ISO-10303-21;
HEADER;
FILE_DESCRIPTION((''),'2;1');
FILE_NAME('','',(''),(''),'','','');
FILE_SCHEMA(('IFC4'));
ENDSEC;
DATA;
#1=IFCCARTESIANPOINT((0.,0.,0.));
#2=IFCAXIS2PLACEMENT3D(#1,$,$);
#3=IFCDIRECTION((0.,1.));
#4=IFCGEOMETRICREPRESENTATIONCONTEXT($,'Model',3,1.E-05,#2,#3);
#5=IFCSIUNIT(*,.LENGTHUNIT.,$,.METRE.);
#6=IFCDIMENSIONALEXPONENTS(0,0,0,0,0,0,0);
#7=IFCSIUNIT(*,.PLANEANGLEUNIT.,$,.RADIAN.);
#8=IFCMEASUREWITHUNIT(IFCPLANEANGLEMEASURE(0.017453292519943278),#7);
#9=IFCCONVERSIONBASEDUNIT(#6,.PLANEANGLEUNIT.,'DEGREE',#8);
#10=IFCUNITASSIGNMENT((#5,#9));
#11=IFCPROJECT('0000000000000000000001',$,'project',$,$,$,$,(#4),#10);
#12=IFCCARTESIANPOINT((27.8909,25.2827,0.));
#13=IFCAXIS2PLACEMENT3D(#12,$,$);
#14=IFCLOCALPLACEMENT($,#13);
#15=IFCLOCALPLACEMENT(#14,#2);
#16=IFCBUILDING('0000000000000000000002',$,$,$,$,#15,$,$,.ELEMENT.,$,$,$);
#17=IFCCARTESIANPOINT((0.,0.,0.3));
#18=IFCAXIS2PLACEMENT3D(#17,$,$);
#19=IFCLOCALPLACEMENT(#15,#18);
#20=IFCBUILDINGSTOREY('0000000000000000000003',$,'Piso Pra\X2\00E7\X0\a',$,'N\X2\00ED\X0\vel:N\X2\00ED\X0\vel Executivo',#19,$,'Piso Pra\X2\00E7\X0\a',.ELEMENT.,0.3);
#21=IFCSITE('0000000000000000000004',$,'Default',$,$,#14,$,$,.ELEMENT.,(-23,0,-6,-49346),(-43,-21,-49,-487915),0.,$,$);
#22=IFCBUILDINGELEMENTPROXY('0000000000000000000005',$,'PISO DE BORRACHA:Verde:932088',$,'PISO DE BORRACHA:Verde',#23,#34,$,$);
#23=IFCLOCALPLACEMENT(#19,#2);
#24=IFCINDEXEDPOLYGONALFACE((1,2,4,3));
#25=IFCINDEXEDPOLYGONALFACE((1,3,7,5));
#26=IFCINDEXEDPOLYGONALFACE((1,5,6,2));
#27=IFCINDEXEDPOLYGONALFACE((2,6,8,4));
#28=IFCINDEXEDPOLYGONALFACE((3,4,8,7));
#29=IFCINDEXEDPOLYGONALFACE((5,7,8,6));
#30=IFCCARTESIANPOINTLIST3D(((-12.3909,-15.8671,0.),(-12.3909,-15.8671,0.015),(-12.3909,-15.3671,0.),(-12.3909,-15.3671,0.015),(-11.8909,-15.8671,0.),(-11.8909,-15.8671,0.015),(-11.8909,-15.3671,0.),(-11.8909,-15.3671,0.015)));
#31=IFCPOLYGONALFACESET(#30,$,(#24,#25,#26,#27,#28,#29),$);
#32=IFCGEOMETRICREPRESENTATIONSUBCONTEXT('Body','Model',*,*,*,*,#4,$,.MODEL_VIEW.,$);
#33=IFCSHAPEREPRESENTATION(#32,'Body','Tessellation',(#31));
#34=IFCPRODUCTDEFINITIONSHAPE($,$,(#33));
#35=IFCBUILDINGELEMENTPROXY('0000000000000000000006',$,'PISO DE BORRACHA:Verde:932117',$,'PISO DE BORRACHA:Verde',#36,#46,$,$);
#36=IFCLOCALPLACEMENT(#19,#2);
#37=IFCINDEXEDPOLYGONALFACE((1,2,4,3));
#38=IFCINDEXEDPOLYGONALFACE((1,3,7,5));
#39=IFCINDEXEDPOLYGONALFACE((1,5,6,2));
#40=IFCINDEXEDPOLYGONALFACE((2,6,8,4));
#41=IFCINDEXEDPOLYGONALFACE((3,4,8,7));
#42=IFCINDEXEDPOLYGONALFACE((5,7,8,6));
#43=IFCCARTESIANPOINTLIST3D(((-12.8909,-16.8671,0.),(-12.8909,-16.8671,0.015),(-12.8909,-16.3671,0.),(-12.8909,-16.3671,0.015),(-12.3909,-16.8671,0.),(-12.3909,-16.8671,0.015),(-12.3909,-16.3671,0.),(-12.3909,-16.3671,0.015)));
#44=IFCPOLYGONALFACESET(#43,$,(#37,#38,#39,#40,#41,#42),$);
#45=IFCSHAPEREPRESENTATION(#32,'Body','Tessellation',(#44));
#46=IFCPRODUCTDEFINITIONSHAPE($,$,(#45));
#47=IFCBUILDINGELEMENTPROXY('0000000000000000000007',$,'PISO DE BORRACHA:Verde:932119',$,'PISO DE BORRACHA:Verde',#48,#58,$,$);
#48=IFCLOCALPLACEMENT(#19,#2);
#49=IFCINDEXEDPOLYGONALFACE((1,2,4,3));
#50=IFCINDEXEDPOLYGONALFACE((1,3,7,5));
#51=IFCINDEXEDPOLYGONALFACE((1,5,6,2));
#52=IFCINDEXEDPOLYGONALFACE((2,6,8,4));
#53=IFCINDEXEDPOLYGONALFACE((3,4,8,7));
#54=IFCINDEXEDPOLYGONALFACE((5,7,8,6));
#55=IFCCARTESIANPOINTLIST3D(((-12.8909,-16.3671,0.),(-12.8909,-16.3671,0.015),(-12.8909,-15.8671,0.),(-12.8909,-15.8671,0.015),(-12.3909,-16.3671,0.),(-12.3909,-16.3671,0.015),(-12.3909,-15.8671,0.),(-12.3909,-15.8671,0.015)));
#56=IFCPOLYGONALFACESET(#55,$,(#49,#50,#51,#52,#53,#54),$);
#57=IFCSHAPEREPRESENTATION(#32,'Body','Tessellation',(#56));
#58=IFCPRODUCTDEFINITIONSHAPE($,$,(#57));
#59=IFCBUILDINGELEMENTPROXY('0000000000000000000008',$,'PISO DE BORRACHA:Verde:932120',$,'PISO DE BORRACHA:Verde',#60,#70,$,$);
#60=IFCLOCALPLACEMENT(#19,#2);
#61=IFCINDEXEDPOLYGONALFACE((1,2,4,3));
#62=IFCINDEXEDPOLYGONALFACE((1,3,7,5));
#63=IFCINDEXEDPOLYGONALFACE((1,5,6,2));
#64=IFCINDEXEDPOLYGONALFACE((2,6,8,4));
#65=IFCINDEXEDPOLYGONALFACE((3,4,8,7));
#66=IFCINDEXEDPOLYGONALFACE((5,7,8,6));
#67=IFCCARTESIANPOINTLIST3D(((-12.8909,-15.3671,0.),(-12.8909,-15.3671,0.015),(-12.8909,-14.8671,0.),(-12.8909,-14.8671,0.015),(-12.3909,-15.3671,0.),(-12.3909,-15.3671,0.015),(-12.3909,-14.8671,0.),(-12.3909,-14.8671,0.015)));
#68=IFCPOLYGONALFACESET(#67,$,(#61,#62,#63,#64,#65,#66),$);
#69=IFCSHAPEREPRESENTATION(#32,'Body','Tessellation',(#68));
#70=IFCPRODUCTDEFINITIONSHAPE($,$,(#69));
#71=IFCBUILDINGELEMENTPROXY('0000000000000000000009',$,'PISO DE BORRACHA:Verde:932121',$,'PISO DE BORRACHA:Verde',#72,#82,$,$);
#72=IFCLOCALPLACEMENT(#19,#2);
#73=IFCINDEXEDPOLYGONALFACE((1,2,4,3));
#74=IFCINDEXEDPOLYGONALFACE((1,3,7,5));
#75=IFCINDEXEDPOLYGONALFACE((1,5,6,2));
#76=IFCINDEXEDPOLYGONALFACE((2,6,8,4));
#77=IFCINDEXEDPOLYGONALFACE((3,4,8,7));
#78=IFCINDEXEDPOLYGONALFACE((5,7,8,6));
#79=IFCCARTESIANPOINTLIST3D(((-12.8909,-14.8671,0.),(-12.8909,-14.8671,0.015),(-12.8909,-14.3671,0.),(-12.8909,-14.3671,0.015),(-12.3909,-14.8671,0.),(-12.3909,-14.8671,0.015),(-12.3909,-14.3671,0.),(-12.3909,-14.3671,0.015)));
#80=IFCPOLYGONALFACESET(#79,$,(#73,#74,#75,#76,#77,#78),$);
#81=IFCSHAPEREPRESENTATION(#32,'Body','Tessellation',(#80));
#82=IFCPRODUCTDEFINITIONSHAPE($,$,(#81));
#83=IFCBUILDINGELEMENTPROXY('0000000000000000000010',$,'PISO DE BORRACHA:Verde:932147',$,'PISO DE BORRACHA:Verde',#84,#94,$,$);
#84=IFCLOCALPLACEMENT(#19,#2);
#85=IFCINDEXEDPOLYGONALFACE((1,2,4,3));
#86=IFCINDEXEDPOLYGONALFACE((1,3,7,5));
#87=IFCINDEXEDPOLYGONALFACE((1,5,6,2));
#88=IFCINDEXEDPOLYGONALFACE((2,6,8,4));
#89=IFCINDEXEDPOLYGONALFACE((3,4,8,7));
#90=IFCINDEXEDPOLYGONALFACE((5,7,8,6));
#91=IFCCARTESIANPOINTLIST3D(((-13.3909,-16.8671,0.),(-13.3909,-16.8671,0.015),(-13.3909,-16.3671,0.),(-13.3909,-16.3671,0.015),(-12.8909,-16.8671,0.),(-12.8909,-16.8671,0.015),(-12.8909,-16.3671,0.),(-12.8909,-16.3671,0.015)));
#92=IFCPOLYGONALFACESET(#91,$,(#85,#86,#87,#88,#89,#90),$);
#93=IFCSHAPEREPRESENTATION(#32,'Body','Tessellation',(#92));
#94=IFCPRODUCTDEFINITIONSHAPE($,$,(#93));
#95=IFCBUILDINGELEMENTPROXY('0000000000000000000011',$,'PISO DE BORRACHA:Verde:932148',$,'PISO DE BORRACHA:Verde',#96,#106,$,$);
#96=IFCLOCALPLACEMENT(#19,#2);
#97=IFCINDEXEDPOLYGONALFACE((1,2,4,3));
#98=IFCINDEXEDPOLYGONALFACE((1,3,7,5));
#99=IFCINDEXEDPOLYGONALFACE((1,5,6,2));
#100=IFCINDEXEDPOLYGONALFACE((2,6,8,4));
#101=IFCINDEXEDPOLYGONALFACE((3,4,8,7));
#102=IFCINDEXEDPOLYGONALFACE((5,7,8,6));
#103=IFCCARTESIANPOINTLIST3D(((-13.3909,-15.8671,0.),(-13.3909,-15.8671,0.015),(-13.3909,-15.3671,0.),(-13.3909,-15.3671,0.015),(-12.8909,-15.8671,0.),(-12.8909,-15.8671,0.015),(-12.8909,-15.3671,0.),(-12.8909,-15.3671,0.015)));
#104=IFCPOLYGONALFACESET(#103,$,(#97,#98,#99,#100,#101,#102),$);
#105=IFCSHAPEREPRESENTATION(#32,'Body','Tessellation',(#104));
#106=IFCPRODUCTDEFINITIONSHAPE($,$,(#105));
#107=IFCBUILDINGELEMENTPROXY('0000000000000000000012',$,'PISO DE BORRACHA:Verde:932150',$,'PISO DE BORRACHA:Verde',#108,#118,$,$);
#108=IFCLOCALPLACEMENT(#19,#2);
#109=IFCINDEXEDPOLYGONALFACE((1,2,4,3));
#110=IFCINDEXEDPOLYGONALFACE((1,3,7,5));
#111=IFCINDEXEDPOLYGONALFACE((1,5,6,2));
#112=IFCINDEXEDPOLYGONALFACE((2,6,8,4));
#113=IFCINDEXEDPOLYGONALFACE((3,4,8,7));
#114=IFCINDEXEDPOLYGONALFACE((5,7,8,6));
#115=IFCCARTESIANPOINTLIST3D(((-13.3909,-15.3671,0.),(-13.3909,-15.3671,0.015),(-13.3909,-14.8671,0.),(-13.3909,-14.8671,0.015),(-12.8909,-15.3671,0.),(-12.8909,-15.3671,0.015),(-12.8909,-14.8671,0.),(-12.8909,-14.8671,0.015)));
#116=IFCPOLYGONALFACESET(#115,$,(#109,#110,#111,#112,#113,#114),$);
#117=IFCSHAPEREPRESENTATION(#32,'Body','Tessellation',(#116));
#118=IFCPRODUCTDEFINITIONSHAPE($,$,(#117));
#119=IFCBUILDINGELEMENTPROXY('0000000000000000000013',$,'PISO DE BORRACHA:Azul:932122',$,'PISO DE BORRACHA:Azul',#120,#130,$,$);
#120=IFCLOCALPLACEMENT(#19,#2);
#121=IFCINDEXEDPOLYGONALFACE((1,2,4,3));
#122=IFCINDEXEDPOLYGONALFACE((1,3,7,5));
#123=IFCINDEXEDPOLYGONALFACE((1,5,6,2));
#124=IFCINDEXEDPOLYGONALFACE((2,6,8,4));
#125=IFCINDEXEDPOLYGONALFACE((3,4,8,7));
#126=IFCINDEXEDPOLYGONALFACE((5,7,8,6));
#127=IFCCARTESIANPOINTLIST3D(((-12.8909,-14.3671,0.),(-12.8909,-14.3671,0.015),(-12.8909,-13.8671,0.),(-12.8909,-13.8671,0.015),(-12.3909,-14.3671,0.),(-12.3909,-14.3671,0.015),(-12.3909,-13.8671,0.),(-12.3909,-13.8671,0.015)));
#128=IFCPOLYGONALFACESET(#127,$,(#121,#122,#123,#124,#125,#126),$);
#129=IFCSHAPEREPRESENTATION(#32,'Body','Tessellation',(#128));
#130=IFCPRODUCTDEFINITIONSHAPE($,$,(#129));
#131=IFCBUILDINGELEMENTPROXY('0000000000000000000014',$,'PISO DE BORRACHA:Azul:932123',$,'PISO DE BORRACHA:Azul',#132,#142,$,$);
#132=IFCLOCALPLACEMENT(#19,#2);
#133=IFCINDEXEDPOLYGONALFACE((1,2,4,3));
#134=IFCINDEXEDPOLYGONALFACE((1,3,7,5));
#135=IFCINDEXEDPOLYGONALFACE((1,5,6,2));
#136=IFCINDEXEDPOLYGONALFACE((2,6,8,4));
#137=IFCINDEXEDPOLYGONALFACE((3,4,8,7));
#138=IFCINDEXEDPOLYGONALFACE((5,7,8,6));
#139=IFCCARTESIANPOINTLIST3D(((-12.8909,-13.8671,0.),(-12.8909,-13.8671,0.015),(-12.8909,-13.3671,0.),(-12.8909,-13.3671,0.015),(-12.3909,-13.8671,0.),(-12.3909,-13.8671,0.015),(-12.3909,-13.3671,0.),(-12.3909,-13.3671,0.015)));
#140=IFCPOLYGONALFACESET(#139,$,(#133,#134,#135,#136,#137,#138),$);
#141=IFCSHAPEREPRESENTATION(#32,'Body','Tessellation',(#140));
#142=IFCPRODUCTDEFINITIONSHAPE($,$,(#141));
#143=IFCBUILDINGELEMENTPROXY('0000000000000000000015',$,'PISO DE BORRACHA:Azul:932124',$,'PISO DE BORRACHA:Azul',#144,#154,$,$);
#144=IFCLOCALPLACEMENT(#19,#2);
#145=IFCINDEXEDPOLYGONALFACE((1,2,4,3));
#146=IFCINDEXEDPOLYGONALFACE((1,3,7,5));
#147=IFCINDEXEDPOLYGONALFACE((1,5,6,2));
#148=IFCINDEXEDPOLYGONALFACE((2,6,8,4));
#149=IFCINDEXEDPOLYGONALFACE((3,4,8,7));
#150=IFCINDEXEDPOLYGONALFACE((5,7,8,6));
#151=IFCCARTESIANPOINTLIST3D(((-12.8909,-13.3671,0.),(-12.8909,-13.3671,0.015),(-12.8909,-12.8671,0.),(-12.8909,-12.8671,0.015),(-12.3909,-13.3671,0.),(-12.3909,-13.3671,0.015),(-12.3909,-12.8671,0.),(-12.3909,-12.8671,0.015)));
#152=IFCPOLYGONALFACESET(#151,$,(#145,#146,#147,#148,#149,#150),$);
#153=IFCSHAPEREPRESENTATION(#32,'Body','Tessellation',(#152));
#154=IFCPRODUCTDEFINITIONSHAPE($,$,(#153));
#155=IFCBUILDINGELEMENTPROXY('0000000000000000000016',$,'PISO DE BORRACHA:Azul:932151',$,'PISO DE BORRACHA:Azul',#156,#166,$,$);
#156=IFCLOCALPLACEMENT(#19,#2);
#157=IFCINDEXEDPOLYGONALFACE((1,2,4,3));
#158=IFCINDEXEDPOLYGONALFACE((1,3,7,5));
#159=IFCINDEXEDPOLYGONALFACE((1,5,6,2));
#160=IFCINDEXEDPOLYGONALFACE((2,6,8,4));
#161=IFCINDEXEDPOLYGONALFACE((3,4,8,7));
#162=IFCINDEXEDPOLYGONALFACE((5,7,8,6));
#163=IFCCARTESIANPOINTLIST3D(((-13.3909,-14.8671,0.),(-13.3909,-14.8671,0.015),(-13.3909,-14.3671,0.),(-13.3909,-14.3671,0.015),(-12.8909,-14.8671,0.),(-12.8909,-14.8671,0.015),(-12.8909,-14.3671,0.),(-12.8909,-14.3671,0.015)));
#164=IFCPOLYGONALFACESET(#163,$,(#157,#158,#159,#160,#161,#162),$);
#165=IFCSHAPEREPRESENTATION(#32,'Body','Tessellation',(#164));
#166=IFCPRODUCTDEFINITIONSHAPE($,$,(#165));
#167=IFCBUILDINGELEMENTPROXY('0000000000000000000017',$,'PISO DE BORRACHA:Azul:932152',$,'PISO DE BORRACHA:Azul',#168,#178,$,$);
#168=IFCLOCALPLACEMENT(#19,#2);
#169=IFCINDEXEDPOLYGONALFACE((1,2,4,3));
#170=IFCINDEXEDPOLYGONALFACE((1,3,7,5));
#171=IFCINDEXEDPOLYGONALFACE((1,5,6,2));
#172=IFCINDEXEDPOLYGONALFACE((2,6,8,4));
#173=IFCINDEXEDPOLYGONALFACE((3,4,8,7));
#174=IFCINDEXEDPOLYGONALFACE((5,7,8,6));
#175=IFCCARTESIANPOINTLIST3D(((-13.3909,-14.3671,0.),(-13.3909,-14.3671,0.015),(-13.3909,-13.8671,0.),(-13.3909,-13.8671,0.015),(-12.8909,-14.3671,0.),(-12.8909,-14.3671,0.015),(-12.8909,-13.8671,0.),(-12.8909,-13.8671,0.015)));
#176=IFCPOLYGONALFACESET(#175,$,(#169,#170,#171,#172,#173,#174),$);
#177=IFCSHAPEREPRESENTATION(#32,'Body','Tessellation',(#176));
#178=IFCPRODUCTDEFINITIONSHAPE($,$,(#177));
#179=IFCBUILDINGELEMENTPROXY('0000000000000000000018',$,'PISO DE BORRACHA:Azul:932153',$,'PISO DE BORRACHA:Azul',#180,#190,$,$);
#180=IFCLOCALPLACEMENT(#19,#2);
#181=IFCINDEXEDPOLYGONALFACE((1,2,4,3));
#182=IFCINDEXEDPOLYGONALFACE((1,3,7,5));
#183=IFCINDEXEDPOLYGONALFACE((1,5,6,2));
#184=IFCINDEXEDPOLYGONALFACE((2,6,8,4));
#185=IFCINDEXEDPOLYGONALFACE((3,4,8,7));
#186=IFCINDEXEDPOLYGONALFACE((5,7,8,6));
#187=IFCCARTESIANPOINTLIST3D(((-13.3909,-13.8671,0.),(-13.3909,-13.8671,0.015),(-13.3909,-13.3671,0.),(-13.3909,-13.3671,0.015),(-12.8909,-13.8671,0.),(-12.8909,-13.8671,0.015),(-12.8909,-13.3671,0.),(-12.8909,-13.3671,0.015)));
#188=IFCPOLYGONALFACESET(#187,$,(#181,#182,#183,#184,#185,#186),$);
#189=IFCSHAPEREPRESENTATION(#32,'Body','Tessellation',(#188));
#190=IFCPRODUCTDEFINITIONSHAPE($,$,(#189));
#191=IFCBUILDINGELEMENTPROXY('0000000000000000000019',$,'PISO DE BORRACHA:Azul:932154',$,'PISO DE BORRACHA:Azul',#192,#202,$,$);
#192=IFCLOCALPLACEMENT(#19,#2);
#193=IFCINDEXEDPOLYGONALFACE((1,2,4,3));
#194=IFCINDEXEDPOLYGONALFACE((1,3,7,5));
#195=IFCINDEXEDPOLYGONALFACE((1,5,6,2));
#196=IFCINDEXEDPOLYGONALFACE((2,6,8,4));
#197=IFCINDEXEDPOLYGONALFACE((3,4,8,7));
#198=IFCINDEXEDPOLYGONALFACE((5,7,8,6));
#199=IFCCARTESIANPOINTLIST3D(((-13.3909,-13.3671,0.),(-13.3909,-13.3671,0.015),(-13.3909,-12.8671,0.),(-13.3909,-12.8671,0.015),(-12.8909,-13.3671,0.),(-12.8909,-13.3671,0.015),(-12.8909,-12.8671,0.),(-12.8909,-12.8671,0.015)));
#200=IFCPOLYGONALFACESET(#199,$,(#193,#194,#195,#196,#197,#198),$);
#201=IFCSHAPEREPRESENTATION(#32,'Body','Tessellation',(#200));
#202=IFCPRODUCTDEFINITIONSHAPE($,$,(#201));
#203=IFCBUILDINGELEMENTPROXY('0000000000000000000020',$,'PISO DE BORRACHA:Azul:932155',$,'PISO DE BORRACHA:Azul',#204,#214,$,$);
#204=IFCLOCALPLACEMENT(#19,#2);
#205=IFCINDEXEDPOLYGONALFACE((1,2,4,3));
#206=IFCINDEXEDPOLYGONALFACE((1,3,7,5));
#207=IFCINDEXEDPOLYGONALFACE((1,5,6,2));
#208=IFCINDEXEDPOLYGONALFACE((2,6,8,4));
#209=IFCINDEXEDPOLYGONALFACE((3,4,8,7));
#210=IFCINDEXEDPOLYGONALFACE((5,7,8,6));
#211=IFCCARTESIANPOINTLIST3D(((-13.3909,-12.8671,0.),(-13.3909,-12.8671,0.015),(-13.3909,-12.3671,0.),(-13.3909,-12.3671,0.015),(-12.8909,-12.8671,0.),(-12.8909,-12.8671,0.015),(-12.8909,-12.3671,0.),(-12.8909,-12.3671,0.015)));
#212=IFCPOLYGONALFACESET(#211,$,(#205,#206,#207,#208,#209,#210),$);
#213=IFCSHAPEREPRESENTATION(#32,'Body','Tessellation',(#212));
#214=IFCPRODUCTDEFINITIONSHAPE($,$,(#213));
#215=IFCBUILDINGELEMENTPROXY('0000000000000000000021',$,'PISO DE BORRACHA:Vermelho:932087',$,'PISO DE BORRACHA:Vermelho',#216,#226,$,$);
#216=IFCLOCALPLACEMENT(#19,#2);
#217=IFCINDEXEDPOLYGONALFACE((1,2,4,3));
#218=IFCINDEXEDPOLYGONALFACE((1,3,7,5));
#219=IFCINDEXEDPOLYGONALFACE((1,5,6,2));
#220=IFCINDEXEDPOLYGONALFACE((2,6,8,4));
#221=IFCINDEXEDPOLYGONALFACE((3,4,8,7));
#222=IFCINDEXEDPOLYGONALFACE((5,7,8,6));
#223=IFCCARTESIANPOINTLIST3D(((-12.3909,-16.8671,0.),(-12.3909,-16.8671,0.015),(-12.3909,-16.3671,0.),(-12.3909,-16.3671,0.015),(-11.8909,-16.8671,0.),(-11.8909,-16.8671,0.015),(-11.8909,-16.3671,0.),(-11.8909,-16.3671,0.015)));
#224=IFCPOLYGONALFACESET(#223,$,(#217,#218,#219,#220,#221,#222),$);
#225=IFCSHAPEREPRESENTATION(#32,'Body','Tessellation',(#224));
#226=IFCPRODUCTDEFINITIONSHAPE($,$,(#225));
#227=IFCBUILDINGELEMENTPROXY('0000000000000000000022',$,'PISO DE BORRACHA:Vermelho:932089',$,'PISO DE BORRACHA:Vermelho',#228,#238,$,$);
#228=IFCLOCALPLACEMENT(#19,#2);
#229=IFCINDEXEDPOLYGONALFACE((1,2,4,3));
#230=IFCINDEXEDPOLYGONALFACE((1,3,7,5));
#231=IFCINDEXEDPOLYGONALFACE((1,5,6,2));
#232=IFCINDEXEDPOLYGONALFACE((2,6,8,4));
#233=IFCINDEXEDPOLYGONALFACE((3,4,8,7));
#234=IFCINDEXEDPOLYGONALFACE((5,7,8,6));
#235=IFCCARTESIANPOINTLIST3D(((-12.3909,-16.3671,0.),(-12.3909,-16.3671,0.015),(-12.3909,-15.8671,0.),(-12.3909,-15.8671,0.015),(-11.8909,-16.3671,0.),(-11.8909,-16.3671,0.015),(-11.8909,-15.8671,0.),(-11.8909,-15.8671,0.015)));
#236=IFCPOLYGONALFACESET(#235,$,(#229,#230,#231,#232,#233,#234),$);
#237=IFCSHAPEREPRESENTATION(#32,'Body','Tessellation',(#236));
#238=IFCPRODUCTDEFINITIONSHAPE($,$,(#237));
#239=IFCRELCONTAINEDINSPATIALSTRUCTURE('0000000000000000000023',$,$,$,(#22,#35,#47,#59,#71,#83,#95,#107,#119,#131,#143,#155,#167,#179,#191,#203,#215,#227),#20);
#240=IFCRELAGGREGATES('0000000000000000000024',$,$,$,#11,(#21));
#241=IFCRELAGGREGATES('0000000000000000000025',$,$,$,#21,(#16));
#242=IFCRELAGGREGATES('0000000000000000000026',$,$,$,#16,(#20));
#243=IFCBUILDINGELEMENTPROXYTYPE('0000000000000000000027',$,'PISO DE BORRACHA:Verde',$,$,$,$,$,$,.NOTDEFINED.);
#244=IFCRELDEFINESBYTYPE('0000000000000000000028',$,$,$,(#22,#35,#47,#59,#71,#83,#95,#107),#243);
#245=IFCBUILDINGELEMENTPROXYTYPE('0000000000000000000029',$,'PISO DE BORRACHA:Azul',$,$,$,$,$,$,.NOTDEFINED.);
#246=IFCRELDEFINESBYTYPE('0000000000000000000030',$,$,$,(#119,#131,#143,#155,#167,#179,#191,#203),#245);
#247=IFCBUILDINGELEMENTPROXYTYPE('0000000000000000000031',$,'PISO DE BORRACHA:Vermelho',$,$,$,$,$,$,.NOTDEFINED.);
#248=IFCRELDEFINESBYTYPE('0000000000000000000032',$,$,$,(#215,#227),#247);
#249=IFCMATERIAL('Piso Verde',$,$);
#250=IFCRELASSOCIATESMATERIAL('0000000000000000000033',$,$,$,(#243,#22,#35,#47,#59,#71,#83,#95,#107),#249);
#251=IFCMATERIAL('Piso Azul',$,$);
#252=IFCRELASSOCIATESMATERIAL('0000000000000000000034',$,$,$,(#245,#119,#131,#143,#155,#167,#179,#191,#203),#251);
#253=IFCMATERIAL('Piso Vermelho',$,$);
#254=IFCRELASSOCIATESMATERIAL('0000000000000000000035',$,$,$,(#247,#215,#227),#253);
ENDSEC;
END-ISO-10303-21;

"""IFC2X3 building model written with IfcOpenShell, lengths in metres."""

from ifc_helpers import new_model, entity, si_unit, converted_unit, direction, frame, origin, origin_2d_with_axis, place, context, subcontext, project, spatial, rectangle, extrude, source, transform, mapped, material, type_object, type_shapes, element, save


model = new_model("IFC2X3")

# Units and contexts
model_context = context("Model", 3, precision=1e-05, world=origin(), true_north=direction((0.0, 1.0)))
body_context = subcontext(model_context, "Body", "Model", "MODEL_VIEW")
ifc_project = project(units=[si_unit("LENGTHUNIT", "METRE"), converted_unit("PLANEANGLEUNIT", "DEGREE", entity("IfcPlaneAngleMeasure", 0.017453292519943278), si_unit("PLANEANGLEUNIT", "RADIAN"), dimensions=[0, 0, 0, 0, 0, 0, 0])], contexts=[model_context])

# Site, building, storey
site_placement = place(None, frame((27.8909, 25.2827, 0.0)))
site = spatial("IfcSite", under=ifc_project, at=site_placement, Name="Default", CompositionType="ELEMENT", RefLatitude=(-23, 0, -6, -49346), RefLongitude=(-43, -21, -49, -487915), RefElevation=0.0)
building_placement = place(site_placement, origin())
building = spatial("IfcBuilding", under=site, at=building_placement, CompositionType="ELEMENT")
storey_placement = place(building_placement, frame((0.0, 0.0, 0.3)))
storey = spatial("IfcBuildingStorey", under=building, at=storey_placement, Name="Piso Praça", ObjectType="Nível:Nível Executivo", LongName="Piso Praça", CompositionType="ELEMENT", Elevation=0.3)

# Building element proxies
ifc_material_1 = material(Name="Piso Verde")
building_element_proxy_type_1 = type_object("IfcBuildingElementProxyType", Name="PISO DE BORRACHA:Verde", PredefinedType="NOTDEFINED", material=ifc_material_1)
shared_shape_1 = source(origin(), body_context, "Body", "SweptSolid", [
    extrude(rectangle(XDim=0.5, YDim=0.5, at=origin_2d_with_axis()), frame((0.25, 0.25, 0.0), z_axis=(0.0, 0.0, 1.0), x_axis=(-1.0, 0.0, 0.0)), (0.0, 0.0, 1.0), 0.015),
])
type_shapes(building_element_proxy_type_1, [shared_shape_1])
for number, where, z_axis, x_axis, name in (
    (1, (-12.3909, -15.3671, 0.0), (0.0, 0.0, 1.0), (0.0, -1.0, 0.0), "PISO DE BORRACHA:Verde:932088"),
    (2, (-12.8909, -16.3671, 0.0), (0.0, 0.0, 1.0), (0.0, -1.0, 0.0), "PISO DE BORRACHA:Verde:932117"),
    (3, (-12.8909, -15.8671, 0.0), (0.0, 0.0, 1.0), (0.0, -1.0, 0.0), "PISO DE BORRACHA:Verde:932119"),
    (4, (-12.8909, -14.8671, 0.0), (0.0, 0.0, 1.0), (0.0, -1.0, 0.0), "PISO DE BORRACHA:Verde:932120"),
    (5, (-12.8909, -14.3671, 0.0), (0.0, 0.0, 1.0), (0.0, -1.0, 0.0), "PISO DE BORRACHA:Verde:932121"),
    (6, (-13.3909, -16.3671, 0.0), (0.0, 0.0, 1.0), (0.0, -1.0, 0.0), "PISO DE BORRACHA:Verde:932147"),
    (7, (-13.3909, -15.3671, 0.0), (0.0, 0.0, 1.0), (0.0, -1.0, 0.0), "PISO DE BORRACHA:Verde:932148"),
    (8, (-13.3909, -14.8671, 0.0), (0.0, 0.0, 1.0), (0.0, -1.0, 0.0), "PISO DE BORRACHA:Verde:932150"),
):
    element("IfcBuildingElementProxy", number, at=place(storey_placement, frame(where, z_axis=z_axis, x_axis=x_axis)), inside=storey, type_object=building_element_proxy_type_1, material=ifc_material_1, Name=name, ObjectType="PISO DE BORRACHA:Verde", context=body_context, shape_type="MappedRepresentation", body=[
        mapped(shared_shape_1, transform((0.0, 0.0, 0.0), scale=1.0)),
    ])
ifc_material_2 = material(Name="Piso Azul")
building_element_proxy_type_2 = type_object("IfcBuildingElementProxyType", Name="PISO DE BORRACHA:Azul", PredefinedType="NOTDEFINED", material=ifc_material_2)
shared_shape_2 = source(origin(), body_context, "Body", "SweptSolid", [
    extrude(rectangle(XDim=0.5, YDim=0.5, at=origin_2d_with_axis()), frame((0.25, 0.25, 0.0), z_axis=(0.0, 0.0, 1.0), x_axis=(-1.0, 0.0, 0.0)), (0.0, 0.0, 1.0), 0.015),
])
type_shapes(building_element_proxy_type_2, [shared_shape_2])
for number, where, z_axis, x_axis, name in (
    (9, (-12.8909, -13.8671, 0.0), (0.0, 0.0, 1.0), (0.0, -1.0, 0.0), "PISO DE BORRACHA:Azul:932122"),
    (10, (-12.8909, -13.3671, 0.0), (0.0, 0.0, 1.0), (0.0, -1.0, 0.0), "PISO DE BORRACHA:Azul:932123"),
    (11, (-12.8909, -12.8671, 0.0), (0.0, 0.0, 1.0), (0.0, -1.0, 0.0), "PISO DE BORRACHA:Azul:932124"),
    (12, (-13.3909, -14.3671, 0.0), (0.0, 0.0, 1.0), (0.0, -1.0, 0.0), "PISO DE BORRACHA:Azul:932151"),
    (13, (-13.3909, -13.8671, 0.0), (0.0, 0.0, 1.0), (0.0, -1.0, 0.0), "PISO DE BORRACHA:Azul:932152"),
    (14, (-13.3909, -13.3671, 0.0), (0.0, 0.0, 1.0), (0.0, -1.0, 0.0), "PISO DE BORRACHA:Azul:932153"),
    (15, (-13.3909, -12.8671, 0.0), (0.0, 0.0, 1.0), (0.0, -1.0, 0.0), "PISO DE BORRACHA:Azul:932154"),
    (16, (-13.3909, -12.3671, 0.0), (0.0, 0.0, 1.0), (0.0, -1.0, 0.0), "PISO DE BORRACHA:Azul:932155"),
):
    element("IfcBuildingElementProxy", number, at=place(storey_placement, frame(where, z_axis=z_axis, x_axis=x_axis)), inside=storey, type_object=building_element_proxy_type_2, material=ifc_material_2, Name=name, ObjectType="PISO DE BORRACHA:Azul", context=body_context, shape_type="MappedRepresentation", body=[
        mapped(shared_shape_2, transform((0.0, 0.0, 0.0), scale=1.0)),
    ])
ifc_material_3 = material(Name="Piso Vermelho")
building_element_proxy_type_3 = type_object("IfcBuildingElementProxyType", Name="PISO DE BORRACHA:Vermelho", PredefinedType="NOTDEFINED", material=ifc_material_3)
shared_shape_3 = source(origin(), body_context, "Body", "SweptSolid", [
    extrude(rectangle(XDim=0.5, YDim=0.5, at=origin_2d_with_axis()), frame((0.25, 0.25, 0.0), z_axis=(0.0, 0.0, 1.0), x_axis=(-1.0, 0.0, 0.0)), (0.0, 0.0, 1.0), 0.015),
])
type_shapes(building_element_proxy_type_3, [shared_shape_3])
for number, where, z_axis, x_axis, name in (
    (17, (-12.3909, -16.3671, 0.0), (0.0, 0.0, 1.0), (0.0, -1.0, 0.0), "PISO DE BORRACHA:Vermelho:932087"),
    (18, (-12.3909, -15.8671, 0.0), (0.0, 0.0, 1.0), (0.0, -1.0, 0.0), "PISO DE BORRACHA:Vermelho:932089"),
):
    element("IfcBuildingElementProxy", number, at=place(storey_placement, frame(where, z_axis=z_axis, x_axis=x_axis)), inside=storey, type_object=building_element_proxy_type_3, material=ifc_material_3, Name=name, ObjectType="PISO DE BORRACHA:Vermelho", context=body_context, shape_type="MappedRepresentation", body=[
        mapped(shared_shape_3, transform((0.0, 0.0, 0.0), scale=1.0)),
    ])

save(model, "model.ifc")
